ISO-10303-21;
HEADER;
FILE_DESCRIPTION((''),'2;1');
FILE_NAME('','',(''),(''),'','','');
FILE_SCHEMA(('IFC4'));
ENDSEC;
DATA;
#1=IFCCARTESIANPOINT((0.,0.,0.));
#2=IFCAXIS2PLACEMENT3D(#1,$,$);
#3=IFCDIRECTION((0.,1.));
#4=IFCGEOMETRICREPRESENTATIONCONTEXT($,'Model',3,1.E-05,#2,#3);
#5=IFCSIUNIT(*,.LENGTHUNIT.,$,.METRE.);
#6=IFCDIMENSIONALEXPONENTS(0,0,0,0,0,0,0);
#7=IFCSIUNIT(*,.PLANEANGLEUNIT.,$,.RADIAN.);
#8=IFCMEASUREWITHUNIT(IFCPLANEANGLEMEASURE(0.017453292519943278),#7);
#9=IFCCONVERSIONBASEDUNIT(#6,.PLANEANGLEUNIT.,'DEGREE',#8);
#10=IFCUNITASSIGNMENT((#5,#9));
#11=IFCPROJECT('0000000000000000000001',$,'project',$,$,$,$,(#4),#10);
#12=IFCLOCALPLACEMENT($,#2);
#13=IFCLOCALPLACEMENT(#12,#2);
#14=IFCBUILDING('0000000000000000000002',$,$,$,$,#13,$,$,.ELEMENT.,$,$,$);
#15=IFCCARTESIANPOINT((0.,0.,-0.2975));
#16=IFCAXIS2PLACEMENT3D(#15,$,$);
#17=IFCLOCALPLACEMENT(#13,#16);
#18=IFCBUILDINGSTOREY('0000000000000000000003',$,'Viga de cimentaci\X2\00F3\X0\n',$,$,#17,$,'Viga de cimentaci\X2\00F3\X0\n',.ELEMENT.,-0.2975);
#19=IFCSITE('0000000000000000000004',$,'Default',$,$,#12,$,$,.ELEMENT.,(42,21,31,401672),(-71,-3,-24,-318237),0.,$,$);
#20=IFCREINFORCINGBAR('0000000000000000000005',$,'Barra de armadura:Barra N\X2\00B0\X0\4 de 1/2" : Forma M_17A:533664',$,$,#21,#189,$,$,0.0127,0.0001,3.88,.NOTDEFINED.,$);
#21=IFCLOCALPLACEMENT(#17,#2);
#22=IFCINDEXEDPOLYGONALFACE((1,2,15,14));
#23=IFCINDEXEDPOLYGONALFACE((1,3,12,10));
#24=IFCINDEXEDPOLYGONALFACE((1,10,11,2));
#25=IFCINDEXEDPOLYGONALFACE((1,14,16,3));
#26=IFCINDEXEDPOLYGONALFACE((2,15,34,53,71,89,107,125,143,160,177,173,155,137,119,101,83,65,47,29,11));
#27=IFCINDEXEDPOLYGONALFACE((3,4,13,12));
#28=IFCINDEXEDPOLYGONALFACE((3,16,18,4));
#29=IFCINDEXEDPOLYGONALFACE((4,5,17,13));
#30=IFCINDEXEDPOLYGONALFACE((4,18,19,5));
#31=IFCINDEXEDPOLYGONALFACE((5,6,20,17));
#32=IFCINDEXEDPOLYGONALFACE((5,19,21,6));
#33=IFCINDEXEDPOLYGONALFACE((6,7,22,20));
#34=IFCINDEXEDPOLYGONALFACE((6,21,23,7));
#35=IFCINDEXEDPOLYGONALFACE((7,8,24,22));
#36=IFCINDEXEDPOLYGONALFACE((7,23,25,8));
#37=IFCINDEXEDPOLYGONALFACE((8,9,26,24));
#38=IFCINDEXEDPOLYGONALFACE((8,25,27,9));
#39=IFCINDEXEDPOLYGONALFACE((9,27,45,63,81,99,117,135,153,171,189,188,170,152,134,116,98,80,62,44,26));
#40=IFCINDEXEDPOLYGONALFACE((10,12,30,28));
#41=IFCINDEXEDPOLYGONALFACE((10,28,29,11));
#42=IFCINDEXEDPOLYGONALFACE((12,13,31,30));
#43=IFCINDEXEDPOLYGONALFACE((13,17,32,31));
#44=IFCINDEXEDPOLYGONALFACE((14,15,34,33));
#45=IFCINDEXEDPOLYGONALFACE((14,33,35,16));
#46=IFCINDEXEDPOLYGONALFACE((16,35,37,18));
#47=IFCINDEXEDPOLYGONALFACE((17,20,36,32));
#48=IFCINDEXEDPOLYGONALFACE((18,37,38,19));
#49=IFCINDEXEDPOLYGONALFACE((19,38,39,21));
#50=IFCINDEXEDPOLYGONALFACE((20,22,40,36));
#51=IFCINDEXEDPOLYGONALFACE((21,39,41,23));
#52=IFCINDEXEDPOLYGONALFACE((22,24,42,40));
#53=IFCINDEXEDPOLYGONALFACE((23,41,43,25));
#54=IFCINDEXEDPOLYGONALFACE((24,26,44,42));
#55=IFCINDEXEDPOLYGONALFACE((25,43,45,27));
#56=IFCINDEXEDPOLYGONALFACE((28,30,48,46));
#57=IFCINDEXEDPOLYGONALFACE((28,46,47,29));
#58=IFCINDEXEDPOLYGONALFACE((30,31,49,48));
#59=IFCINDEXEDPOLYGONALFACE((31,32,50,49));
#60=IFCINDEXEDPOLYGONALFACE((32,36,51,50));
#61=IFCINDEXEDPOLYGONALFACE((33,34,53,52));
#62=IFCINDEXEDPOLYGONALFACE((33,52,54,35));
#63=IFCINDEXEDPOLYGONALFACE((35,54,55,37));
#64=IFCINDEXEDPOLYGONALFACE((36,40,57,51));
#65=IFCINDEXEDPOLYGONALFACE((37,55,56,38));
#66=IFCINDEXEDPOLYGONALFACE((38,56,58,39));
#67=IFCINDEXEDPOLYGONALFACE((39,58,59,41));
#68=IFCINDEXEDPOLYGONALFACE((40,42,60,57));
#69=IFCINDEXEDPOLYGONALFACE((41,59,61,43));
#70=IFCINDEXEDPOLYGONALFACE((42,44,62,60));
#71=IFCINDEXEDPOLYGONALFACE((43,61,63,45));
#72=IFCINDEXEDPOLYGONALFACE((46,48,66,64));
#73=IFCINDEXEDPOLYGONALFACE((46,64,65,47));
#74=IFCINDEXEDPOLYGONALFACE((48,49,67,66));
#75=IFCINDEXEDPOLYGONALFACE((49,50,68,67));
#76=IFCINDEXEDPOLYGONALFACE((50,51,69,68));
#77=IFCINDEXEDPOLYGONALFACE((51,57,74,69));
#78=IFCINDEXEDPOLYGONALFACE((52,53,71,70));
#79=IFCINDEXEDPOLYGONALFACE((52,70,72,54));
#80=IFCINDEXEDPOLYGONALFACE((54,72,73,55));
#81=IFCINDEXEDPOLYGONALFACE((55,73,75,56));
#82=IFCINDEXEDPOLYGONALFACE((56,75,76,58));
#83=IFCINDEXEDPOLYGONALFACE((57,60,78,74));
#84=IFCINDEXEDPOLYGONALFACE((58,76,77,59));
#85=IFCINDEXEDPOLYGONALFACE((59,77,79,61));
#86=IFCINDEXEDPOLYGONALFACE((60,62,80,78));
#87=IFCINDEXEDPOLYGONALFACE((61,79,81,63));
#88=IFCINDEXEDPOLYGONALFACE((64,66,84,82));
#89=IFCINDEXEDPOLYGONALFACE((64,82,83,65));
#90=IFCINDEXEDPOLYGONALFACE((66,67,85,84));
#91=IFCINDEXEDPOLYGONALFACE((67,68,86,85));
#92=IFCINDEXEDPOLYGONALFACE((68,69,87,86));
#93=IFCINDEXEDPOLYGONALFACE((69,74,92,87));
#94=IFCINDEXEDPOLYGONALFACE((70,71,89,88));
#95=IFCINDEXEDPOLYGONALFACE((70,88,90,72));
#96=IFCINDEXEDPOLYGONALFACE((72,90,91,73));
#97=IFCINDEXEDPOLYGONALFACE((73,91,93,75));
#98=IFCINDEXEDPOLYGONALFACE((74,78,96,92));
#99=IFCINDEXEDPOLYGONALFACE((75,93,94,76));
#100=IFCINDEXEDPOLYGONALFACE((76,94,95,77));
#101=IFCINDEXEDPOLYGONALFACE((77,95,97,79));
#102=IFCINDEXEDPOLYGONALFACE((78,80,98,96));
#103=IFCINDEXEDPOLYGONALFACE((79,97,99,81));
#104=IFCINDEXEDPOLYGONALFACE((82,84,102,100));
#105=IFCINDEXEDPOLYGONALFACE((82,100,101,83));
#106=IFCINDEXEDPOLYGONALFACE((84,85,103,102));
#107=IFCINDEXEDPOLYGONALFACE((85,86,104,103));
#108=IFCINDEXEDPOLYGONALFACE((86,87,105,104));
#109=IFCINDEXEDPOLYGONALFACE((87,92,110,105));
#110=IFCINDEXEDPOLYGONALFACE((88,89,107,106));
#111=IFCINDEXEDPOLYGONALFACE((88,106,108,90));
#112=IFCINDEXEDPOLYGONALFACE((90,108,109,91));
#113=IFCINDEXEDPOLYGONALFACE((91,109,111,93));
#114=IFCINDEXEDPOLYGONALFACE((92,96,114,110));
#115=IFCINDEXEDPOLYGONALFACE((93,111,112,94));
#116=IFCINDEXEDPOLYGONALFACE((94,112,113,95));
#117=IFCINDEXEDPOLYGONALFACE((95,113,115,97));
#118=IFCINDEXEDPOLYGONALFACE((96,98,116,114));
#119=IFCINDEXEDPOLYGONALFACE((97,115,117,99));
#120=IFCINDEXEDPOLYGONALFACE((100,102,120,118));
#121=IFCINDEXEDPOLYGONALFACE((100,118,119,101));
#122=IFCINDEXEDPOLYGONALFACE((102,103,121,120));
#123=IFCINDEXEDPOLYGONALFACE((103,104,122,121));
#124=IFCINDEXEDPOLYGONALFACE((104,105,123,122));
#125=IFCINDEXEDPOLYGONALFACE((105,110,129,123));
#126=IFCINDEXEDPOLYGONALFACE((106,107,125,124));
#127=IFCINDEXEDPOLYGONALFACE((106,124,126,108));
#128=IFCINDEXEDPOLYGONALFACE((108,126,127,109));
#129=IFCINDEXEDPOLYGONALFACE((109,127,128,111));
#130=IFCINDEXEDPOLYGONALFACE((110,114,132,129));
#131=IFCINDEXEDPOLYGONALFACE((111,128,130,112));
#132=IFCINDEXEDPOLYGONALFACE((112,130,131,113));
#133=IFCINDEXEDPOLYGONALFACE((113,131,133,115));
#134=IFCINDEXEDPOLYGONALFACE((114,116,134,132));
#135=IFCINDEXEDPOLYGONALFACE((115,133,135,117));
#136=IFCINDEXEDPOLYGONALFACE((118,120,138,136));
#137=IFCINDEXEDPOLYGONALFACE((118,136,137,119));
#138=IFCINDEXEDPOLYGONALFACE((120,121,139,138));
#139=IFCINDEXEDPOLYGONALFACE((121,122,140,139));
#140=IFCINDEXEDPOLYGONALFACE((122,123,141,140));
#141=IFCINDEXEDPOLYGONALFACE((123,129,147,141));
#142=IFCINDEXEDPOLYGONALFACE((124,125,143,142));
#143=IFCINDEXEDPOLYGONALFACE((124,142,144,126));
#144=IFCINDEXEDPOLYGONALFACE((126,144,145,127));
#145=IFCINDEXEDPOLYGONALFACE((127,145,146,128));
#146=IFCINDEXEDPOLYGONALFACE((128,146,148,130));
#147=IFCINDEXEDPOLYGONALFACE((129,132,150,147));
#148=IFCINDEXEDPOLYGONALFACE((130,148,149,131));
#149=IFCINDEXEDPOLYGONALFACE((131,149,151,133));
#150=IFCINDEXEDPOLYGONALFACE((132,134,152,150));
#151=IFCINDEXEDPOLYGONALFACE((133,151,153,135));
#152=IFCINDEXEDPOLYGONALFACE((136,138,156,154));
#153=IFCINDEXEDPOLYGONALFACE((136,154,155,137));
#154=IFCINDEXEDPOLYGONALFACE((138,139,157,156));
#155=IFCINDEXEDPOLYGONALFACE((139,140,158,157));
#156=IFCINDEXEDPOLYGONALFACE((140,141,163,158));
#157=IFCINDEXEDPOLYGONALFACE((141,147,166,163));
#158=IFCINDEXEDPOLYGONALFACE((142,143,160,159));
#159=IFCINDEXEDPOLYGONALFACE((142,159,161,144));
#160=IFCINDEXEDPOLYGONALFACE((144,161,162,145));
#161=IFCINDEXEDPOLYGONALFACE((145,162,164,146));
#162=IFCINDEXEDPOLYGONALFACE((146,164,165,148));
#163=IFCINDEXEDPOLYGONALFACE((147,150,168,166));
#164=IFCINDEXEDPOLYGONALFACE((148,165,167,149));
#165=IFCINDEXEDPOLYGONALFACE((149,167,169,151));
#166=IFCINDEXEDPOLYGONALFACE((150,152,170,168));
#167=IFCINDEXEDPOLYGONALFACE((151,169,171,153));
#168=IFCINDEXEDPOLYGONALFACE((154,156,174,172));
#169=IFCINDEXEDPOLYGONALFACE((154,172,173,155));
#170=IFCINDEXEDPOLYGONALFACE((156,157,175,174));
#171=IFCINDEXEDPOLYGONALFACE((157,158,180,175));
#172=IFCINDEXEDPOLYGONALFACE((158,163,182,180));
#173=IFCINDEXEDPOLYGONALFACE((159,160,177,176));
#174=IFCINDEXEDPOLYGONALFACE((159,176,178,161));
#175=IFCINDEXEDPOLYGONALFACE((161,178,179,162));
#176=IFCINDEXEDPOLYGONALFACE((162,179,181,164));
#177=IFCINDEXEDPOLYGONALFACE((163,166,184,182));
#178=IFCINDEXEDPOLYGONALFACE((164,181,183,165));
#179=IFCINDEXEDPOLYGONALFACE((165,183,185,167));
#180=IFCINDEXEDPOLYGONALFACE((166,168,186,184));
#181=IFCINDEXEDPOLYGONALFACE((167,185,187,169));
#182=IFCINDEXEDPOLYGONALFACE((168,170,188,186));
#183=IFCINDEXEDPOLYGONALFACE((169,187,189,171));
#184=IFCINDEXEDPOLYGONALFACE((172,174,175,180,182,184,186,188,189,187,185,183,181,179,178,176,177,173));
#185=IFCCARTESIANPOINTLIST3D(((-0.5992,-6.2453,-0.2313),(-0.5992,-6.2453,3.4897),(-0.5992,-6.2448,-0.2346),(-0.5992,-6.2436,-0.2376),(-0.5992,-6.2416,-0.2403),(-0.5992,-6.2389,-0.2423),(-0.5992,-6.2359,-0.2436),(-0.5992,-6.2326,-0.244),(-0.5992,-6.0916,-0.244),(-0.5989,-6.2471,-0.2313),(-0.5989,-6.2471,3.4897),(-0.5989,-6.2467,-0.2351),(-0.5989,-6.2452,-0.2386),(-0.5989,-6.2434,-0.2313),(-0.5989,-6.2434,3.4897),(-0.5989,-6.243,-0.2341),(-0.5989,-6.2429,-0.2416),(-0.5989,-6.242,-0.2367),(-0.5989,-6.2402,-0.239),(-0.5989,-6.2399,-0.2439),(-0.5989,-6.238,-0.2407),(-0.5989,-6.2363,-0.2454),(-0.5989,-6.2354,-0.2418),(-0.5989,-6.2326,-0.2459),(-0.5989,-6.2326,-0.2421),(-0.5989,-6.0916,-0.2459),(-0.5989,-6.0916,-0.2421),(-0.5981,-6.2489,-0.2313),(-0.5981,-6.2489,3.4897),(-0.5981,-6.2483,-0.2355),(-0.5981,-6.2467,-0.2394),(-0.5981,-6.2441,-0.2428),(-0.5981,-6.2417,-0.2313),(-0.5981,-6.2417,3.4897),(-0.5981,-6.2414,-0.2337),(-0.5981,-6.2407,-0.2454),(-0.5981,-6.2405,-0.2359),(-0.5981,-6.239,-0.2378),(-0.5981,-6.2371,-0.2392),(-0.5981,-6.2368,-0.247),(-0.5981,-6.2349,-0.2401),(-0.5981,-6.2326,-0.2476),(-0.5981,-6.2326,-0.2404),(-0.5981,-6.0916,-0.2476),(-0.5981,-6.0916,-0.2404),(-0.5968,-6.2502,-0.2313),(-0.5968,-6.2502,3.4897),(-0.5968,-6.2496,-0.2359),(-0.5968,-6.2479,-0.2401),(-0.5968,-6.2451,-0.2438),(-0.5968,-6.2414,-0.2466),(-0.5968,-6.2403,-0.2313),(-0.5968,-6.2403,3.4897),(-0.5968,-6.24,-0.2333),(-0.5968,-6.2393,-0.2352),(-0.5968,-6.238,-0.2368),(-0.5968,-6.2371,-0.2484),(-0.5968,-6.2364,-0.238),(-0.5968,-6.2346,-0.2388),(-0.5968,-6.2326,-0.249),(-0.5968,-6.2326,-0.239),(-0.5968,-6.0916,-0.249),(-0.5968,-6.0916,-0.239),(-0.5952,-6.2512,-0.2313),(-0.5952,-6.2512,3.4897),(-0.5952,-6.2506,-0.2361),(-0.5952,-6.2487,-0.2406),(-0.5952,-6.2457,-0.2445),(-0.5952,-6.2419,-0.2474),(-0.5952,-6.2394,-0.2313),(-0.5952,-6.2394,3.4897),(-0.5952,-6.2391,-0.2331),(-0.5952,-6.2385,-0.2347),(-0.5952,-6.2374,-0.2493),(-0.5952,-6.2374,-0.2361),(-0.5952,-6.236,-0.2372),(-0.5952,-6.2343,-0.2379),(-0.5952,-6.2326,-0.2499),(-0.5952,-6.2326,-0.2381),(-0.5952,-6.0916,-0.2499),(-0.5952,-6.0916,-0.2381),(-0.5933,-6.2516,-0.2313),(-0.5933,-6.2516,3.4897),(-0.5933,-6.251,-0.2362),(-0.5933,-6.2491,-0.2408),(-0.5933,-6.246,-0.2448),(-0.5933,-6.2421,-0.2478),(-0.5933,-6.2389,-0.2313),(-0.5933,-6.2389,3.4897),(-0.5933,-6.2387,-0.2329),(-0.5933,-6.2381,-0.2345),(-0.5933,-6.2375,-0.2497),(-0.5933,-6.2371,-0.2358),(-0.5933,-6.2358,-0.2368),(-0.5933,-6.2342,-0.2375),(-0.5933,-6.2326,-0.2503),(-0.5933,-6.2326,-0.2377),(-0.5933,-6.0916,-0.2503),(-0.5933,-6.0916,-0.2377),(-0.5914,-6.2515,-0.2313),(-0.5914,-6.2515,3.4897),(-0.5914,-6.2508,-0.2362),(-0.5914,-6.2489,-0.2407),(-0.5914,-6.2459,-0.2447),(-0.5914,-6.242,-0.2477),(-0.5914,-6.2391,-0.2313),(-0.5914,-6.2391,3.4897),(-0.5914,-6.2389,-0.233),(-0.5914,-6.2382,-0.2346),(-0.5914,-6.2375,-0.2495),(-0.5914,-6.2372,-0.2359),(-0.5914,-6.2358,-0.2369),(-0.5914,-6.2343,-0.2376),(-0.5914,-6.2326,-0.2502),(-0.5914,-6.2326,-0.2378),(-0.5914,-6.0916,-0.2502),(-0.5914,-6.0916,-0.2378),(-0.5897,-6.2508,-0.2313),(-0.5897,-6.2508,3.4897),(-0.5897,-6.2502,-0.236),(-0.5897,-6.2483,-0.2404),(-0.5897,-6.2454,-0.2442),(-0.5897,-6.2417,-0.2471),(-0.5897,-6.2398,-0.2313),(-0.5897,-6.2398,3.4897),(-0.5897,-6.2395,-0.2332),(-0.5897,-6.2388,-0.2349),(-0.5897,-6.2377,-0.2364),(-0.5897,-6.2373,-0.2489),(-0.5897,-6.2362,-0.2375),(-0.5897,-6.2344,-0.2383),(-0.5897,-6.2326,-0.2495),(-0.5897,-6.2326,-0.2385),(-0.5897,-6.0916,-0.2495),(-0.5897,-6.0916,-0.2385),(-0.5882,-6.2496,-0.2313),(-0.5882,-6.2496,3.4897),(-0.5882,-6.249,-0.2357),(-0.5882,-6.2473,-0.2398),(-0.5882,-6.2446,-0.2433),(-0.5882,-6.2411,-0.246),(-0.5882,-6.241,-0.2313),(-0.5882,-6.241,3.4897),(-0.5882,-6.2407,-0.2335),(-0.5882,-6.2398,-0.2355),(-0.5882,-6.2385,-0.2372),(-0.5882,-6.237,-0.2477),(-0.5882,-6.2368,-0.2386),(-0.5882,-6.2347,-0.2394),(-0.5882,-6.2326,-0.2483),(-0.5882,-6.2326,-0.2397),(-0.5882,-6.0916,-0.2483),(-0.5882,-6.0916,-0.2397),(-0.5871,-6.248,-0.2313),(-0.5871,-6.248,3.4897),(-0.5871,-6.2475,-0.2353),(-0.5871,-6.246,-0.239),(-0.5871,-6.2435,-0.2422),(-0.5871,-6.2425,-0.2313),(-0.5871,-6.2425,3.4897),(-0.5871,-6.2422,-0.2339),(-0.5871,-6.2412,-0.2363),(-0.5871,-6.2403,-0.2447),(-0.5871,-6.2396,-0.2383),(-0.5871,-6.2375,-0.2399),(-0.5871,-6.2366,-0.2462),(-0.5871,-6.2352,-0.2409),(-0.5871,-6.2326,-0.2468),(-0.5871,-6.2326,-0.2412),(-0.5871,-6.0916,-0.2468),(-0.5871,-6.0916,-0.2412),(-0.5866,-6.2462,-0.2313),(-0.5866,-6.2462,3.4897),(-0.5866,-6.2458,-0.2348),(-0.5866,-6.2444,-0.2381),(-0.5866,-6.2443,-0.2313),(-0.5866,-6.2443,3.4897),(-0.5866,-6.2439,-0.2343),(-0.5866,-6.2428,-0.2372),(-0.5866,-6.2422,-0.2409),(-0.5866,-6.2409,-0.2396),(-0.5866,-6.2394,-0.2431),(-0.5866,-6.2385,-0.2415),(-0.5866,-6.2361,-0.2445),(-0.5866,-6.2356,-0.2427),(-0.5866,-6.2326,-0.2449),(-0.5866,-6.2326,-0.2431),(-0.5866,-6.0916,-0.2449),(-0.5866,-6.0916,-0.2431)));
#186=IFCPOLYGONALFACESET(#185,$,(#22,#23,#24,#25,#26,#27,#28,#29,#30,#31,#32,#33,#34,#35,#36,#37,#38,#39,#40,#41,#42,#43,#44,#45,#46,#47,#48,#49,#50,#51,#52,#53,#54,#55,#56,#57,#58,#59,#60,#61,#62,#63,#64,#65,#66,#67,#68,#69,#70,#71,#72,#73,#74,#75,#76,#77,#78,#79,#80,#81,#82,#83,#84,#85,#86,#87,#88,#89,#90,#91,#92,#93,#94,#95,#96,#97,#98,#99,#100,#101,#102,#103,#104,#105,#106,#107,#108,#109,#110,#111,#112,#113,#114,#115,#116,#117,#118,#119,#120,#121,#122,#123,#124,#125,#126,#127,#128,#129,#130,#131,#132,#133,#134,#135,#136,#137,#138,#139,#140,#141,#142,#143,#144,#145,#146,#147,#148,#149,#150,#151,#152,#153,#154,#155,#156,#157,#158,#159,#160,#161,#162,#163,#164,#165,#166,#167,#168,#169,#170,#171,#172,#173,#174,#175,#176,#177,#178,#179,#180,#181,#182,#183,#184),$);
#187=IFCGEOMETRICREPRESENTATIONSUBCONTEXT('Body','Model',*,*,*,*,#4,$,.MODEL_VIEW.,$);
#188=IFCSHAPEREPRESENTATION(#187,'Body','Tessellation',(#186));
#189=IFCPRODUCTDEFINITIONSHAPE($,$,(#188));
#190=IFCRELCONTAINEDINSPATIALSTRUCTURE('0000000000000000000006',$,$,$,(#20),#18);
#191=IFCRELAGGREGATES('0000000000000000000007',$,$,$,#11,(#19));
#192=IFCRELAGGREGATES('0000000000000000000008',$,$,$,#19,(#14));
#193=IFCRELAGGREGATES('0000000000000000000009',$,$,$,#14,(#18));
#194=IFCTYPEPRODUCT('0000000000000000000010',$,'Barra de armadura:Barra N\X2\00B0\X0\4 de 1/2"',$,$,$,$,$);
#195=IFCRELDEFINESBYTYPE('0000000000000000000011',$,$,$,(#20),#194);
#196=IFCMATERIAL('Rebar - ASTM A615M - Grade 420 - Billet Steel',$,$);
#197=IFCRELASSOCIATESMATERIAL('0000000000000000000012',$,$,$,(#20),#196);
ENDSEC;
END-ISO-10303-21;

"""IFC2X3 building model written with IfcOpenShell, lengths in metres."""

from ifc_helpers import new_model, entity, si_unit, converted_unit, direction, frame, origin, place, context, subcontext, project, spatial, material, type_object, element, save


model = new_model("IFC2X3")

# Units and contexts
model_context = context("Model", 3, precision=1e-05, world=origin(), true_north=direction((0.0, 1.0)))
body_context = subcontext(model_context, "Body", "Model", "MODEL_VIEW")
ifc_project = project(units=[si_unit("LENGTHUNIT", "METRE"), converted_unit("PLANEANGLEUNIT", "DEGREE", entity("IfcPlaneAngleMeasure", 0.017453292519943278), si_unit("PLANEANGLEUNIT", "RADIAN"), dimensions=[0, 0, 0, 0, 0, 0, 0])], contexts=[model_context])

# Site, building, storey
site_placement = place(None, origin())
site = spatial("IfcSite", under=ifc_project, at=site_placement, Name="Default", CompositionType="ELEMENT", RefLatitude=(42, 21, 31, 401672), RefLongitude=(-71, -3, -24, -318237), RefElevation=0.0)
building_placement = place(site_placement, origin())
building = spatial("IfcBuilding", under=site, at=building_placement, CompositionType="ELEMENT")
storey_placement = place(building_placement, frame((0.0, 0.0, -0.2975)))
storey = spatial("IfcBuildingStorey", under=building, at=storey_placement, Name="Viga de cimentación", LongName="Viga de cimentación", CompositionType="ELEMENT", Elevation=-0.2975)

# Reinforcing bar
ifc_material = material(Name="Rebar - ASTM A615M - Grade 420 - Billet Steel")
type_product_1 = type_object("IfcTypeProduct", Name="Barra de armadura:Barra N°4 de 1/2\"")
reinforcing_bar_1_placement = place(storey_placement, origin())
element("IfcReinforcingBar", 1, at=reinforcing_bar_1_placement, inside=storey, type_object=type_product_1, material=ifc_material, Name="Barra de armadura:Barra N°4 de 1/2\" : Forma M_17A:533664", BarLength=3.88, BarRole="NOTDEFINED", CrossSectionArea=0.0001, NominalDiameter=0.0127, context=body_context, shape_type="AdvancedSweptSolid", body=[
    entity("IfcSweptDiskSolid", entity("IfcCompositeCurve", [entity("IfcCompositeCurveSegment", "CONTINUOUS", True, entity("IfcPolyline", [entity("IfcCartesianPoint", [-0.5929, -6.2453, 3.4897]), entity("IfcCartesianPoint", [-0.5929, -6.2453, -0.2313])])), entity("IfcCompositeCurveSegment", "CONTINUOUS", True, entity("IfcTrimmedCurve", entity("IfcCircle", entity("IfcAxis2Placement3D", entity("IfcCartesianPoint", [-0.5929, -6.2326, -0.2313]), entity("IfcDirection", [1.0, 0.0, 0.0]), entity("IfcDirection", [0.0, 0.0, -1.0])), 0.0127), [entity("IfcParameterValue", 270.0)], [entity("IfcParameterValue", 360.0)], True, "PARAMETER")), entity("IfcCompositeCurveSegment", "CONTINUOUS", True, entity("IfcPolyline", [entity("IfcCartesianPoint", [-0.5929, -6.2326, -0.244]), entity("IfcCartesianPoint", [-0.5929, -6.0916, -0.244])]))], False), 0.0063, None, 0.0, 92.0),
])

save(model, "model.ifc")
